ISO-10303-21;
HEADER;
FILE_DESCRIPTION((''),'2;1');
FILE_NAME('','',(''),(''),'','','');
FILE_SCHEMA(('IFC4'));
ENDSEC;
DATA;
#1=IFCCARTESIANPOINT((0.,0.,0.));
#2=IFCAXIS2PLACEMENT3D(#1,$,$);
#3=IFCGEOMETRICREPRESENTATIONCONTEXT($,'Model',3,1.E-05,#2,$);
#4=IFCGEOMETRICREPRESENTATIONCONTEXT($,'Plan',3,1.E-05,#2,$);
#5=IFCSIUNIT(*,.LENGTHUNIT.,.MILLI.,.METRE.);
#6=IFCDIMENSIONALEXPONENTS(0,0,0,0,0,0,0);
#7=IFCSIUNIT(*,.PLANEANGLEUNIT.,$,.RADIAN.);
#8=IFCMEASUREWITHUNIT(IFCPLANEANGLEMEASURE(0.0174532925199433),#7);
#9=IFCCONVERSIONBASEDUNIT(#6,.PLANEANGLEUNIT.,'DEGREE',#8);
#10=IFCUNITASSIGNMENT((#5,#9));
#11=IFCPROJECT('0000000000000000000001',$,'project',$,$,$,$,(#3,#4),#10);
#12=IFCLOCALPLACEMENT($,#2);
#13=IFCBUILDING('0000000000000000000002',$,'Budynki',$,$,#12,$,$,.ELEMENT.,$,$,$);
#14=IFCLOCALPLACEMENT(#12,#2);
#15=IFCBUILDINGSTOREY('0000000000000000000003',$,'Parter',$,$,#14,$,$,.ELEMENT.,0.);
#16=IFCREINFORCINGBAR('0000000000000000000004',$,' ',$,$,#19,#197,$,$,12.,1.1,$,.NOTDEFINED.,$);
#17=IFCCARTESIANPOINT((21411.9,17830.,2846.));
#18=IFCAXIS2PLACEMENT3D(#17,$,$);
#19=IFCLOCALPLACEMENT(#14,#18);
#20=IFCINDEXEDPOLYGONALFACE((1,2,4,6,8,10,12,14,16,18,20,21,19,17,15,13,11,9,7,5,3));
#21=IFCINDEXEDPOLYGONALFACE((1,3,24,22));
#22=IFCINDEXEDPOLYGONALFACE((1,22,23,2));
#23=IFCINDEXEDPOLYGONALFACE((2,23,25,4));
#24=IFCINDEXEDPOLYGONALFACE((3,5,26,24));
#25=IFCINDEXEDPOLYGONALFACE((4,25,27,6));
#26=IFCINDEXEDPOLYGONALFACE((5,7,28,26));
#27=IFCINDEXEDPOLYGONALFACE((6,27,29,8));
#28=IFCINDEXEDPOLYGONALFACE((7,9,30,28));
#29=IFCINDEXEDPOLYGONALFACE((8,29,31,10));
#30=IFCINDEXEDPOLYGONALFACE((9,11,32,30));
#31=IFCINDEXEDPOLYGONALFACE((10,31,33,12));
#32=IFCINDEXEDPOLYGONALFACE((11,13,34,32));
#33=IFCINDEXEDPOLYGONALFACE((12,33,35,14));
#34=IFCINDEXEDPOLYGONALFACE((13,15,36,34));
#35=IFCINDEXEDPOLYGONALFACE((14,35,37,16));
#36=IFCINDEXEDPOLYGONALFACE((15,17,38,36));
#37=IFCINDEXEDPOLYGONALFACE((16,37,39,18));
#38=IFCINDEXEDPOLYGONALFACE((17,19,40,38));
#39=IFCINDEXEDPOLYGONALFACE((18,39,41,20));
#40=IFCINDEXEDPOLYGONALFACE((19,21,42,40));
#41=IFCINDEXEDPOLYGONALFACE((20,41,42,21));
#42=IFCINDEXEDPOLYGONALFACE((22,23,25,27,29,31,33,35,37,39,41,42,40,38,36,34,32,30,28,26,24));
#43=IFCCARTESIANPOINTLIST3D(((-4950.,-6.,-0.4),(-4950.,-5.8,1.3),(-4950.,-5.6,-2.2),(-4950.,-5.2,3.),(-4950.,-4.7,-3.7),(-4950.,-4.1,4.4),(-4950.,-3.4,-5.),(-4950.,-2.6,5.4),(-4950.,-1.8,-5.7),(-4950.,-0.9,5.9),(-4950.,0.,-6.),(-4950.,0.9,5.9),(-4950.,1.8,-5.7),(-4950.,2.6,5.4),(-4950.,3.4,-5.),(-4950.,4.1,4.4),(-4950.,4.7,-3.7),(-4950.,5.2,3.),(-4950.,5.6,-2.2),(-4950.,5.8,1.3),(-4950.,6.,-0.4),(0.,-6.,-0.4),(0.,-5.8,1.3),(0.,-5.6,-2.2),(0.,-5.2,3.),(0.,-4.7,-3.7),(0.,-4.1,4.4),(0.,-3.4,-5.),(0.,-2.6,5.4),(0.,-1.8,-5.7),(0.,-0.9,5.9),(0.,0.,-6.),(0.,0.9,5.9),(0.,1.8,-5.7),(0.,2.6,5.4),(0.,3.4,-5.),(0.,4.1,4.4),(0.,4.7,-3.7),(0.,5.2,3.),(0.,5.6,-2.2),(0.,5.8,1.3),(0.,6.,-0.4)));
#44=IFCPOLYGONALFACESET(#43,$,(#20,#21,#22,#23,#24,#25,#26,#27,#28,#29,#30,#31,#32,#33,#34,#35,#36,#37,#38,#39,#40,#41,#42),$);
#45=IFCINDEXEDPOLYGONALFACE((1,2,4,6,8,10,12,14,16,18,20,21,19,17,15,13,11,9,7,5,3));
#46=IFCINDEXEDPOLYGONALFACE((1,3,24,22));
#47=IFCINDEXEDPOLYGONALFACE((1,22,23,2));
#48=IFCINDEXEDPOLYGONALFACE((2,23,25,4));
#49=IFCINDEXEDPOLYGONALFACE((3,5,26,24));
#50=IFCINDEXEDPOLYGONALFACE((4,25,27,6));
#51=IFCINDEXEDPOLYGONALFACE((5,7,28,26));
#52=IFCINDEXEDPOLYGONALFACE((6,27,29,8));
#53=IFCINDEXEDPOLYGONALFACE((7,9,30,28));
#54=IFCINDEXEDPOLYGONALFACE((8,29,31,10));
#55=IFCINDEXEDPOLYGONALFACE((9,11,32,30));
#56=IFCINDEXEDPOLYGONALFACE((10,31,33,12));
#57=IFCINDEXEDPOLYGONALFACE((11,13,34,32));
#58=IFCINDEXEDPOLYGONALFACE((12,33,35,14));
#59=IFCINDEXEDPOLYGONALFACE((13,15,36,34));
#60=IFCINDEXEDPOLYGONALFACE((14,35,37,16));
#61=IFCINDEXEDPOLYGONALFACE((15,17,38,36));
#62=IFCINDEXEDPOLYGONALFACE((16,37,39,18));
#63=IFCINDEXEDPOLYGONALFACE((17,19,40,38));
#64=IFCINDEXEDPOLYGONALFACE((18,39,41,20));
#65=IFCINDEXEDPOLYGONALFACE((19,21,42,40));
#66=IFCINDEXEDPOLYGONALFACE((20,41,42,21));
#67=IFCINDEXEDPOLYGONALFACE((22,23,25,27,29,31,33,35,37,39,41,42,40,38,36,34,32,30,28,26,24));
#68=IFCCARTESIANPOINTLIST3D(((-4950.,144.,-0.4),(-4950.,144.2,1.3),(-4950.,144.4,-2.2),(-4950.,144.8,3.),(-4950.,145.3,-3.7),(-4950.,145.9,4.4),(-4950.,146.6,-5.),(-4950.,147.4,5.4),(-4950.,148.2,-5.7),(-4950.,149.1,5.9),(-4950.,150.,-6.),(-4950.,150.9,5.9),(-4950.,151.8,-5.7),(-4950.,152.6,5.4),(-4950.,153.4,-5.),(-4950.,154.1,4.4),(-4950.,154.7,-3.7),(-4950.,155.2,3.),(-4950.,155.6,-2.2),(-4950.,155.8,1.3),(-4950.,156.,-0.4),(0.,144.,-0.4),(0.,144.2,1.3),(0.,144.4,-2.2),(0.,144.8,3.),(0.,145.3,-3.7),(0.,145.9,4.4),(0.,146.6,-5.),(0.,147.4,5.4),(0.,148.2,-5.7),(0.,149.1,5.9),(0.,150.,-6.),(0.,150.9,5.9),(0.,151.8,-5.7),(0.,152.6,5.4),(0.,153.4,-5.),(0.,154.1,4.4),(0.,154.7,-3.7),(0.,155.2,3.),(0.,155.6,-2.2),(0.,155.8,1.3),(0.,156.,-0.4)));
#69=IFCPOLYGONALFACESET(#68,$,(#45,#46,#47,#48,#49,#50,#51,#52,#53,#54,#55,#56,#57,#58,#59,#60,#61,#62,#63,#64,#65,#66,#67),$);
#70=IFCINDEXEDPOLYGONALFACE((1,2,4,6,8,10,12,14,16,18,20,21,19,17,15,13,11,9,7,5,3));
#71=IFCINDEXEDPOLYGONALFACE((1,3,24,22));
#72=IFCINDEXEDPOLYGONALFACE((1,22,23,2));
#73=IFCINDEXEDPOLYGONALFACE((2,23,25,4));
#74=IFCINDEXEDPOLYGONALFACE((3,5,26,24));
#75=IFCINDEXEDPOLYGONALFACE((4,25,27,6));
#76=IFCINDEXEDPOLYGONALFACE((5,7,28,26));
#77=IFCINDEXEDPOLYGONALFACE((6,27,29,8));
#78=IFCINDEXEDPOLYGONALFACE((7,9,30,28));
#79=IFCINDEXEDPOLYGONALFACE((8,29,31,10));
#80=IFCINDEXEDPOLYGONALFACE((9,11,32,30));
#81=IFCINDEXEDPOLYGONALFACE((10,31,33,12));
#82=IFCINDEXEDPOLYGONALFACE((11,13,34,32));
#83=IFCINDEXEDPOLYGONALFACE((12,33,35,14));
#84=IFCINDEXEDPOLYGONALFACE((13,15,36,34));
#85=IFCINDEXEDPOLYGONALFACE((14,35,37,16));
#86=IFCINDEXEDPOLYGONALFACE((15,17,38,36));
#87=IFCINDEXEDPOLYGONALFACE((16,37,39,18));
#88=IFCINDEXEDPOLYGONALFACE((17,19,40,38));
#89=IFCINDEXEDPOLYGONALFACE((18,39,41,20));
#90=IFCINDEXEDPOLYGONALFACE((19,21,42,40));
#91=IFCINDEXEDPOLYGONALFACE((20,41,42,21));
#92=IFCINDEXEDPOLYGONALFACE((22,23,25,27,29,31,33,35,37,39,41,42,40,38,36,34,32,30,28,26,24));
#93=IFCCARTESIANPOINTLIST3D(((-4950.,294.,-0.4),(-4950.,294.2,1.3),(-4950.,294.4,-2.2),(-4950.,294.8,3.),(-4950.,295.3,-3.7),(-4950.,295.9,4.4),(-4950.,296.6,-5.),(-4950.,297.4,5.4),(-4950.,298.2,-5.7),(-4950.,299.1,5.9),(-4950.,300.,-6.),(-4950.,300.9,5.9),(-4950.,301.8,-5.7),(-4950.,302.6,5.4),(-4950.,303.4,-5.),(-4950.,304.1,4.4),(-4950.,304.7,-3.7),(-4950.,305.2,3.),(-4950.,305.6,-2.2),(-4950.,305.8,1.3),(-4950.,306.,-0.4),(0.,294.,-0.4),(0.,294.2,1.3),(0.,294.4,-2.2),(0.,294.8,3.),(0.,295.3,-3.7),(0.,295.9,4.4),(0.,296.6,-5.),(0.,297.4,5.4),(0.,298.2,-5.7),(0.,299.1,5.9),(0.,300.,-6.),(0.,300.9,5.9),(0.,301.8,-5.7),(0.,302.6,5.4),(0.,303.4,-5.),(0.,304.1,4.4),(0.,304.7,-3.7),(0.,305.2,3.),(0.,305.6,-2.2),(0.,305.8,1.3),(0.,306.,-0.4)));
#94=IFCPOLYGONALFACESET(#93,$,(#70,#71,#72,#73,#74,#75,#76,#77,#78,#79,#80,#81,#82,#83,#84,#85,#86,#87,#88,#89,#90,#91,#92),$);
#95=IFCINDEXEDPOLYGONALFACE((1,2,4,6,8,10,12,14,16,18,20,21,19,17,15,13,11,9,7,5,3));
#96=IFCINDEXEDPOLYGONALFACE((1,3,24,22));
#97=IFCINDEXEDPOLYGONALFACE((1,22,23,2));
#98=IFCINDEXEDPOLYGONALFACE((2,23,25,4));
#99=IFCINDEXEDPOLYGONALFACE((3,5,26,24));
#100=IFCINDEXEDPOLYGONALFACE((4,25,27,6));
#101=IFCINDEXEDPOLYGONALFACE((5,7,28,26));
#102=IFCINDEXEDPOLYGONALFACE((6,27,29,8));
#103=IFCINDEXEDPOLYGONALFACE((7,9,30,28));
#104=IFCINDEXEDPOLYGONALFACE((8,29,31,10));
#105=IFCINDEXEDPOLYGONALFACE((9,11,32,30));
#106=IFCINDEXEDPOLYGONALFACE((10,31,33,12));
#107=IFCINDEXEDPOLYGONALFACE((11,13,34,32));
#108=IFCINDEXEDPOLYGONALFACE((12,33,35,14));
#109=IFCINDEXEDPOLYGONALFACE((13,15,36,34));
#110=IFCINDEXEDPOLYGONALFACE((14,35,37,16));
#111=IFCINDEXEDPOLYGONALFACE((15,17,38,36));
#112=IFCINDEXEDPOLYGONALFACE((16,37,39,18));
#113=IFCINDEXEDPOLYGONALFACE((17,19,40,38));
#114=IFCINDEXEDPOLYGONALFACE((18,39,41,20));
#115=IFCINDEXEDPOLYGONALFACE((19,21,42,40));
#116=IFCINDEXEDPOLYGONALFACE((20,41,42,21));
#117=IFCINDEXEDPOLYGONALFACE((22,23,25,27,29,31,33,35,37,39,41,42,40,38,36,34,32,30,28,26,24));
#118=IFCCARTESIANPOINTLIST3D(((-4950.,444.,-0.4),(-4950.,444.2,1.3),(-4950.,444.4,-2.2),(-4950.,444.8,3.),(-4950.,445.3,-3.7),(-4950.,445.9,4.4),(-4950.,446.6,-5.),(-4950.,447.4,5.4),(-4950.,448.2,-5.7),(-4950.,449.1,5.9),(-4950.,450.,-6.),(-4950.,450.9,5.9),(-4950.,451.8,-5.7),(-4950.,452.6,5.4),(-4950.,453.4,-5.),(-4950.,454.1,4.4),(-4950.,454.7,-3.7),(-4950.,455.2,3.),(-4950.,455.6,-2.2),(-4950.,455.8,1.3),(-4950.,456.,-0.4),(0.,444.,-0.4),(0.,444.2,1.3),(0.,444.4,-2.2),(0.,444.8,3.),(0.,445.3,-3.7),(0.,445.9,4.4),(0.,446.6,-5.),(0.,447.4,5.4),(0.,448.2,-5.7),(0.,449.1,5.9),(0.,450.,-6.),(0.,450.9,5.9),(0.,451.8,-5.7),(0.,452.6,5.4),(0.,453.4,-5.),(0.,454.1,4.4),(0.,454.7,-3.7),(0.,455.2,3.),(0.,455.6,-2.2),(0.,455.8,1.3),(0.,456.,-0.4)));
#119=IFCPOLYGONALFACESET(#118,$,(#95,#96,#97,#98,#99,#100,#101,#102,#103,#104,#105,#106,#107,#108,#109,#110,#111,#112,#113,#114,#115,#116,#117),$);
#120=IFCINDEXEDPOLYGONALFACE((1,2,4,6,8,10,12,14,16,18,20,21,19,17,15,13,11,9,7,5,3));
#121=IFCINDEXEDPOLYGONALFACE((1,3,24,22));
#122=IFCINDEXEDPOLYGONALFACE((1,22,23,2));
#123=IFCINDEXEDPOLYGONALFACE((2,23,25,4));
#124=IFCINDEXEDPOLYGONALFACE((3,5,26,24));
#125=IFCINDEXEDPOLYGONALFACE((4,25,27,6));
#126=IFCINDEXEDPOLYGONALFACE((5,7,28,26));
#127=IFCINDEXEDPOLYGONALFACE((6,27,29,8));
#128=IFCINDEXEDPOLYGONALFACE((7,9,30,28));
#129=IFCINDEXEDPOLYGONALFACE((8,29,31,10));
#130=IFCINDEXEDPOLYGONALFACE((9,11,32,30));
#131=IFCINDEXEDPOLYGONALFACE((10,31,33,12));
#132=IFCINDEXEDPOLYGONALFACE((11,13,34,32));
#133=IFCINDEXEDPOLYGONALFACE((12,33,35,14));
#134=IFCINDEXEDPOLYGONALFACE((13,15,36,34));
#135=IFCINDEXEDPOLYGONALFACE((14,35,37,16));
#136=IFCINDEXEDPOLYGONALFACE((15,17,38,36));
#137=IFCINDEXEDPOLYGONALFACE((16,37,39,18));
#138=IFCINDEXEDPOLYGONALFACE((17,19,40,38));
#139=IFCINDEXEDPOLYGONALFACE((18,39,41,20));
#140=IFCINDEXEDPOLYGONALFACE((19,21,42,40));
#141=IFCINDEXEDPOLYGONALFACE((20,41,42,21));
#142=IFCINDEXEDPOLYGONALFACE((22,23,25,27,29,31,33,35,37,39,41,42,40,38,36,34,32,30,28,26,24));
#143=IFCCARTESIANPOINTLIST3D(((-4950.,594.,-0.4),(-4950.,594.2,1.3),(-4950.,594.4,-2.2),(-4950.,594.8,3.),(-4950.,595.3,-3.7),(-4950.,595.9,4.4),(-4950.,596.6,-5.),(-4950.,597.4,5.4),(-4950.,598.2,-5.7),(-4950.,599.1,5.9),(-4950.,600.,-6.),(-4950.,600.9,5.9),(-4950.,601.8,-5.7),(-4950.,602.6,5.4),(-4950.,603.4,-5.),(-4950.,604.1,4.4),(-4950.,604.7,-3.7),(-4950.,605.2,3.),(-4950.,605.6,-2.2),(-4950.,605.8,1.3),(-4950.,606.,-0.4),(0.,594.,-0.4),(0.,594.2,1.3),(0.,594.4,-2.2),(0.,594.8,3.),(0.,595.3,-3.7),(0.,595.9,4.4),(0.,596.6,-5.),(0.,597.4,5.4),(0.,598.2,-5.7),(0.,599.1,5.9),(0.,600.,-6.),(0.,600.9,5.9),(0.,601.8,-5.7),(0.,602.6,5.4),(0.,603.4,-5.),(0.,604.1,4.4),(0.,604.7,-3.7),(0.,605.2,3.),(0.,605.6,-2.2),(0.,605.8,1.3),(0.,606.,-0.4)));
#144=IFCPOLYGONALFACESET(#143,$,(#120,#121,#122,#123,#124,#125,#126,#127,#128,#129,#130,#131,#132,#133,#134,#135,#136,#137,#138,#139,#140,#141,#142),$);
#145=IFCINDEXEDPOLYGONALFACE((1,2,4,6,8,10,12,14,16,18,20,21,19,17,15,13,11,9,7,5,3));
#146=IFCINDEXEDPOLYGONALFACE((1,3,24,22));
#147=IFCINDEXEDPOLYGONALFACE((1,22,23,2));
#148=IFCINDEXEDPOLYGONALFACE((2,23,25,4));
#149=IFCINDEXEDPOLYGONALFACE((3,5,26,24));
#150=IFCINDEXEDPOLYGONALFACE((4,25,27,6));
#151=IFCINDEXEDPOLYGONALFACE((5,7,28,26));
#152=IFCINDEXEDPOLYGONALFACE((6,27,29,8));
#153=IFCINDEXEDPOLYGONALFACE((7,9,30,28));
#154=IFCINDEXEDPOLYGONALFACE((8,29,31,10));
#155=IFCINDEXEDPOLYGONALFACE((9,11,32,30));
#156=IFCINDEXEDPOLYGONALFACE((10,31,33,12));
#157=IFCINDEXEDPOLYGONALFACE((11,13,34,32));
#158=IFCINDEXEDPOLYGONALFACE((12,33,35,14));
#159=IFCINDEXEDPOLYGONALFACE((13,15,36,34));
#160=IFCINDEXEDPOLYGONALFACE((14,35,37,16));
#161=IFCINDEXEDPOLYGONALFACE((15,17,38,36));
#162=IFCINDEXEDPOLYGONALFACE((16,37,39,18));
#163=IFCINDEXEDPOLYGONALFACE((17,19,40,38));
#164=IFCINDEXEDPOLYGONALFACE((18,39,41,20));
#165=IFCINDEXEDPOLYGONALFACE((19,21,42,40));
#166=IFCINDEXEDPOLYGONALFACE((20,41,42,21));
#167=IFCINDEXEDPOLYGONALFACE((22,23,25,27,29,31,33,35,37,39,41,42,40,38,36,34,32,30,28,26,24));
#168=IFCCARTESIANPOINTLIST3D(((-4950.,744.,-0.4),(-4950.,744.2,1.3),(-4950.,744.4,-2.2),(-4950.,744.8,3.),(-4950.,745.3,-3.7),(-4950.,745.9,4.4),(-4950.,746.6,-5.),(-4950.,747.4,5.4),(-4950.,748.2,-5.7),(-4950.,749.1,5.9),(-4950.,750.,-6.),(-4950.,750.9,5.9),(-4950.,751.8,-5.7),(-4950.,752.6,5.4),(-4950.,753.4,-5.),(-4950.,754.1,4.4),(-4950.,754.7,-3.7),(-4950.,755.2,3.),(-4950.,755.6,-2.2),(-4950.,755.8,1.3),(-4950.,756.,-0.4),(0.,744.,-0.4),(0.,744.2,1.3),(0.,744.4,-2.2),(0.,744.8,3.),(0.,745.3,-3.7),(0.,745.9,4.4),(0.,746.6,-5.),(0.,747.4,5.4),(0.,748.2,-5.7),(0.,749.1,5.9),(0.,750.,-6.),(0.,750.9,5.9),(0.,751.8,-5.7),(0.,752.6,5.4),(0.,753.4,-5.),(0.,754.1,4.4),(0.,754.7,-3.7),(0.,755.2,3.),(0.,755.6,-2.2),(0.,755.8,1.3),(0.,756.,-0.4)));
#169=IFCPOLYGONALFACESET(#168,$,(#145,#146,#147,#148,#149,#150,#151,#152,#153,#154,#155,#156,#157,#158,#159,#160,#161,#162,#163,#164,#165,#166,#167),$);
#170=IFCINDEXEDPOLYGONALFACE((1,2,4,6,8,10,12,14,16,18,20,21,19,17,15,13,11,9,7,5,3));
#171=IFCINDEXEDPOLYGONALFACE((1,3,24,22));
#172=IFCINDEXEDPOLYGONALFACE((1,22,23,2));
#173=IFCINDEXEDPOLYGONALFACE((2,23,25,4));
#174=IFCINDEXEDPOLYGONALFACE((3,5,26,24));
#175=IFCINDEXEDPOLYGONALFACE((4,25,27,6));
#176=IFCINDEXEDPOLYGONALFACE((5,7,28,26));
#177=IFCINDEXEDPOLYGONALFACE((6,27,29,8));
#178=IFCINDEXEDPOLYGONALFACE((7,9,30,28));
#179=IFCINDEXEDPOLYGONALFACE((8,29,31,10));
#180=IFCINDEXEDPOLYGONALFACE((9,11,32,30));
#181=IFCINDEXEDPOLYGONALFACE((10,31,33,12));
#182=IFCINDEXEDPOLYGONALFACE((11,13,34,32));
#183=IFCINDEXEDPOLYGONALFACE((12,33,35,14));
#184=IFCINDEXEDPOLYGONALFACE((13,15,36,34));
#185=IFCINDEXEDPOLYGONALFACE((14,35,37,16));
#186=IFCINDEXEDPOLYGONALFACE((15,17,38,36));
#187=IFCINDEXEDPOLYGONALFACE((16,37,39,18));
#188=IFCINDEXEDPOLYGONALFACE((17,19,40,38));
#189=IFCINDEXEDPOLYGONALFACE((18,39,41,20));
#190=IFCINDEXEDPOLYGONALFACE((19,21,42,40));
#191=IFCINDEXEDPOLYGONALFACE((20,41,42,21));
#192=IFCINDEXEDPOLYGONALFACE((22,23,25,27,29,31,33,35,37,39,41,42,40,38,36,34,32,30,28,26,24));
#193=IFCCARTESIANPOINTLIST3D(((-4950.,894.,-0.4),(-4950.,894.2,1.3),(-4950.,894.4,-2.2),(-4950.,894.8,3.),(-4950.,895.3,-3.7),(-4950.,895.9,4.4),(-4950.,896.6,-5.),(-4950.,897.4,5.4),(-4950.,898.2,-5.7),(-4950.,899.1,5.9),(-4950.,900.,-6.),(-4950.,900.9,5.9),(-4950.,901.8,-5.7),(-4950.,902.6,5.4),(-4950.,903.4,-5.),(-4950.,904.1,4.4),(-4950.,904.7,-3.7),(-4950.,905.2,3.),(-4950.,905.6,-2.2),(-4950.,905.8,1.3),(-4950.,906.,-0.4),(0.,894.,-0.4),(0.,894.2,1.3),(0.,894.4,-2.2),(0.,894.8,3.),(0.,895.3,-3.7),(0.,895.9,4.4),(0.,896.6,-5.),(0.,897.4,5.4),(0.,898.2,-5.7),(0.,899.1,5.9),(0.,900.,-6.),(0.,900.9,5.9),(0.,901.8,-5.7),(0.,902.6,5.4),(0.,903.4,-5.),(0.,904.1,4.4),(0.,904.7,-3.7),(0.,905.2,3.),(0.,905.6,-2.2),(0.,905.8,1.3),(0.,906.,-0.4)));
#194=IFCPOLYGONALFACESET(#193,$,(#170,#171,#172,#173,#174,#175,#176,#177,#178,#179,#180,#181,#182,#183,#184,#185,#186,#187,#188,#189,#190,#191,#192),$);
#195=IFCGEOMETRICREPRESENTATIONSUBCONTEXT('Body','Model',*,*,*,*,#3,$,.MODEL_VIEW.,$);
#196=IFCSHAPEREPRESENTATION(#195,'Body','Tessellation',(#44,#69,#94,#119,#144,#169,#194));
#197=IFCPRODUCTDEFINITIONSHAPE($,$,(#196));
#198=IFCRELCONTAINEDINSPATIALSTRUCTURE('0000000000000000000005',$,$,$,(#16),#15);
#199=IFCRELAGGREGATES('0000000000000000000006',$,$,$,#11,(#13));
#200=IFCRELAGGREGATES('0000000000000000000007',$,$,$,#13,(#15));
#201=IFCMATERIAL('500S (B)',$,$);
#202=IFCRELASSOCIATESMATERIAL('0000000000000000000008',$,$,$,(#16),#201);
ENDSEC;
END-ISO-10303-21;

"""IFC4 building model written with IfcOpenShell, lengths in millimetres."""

from ifc_helpers import new_model, entity, si_unit, converted_unit, frame, origin, place, context, subcontext, project, spatial, material, element, save


model = new_model("IFC4")

# Units and contexts
model_context = context("Model", 3, precision=1e-05, world=origin())
plan_context = context("Plan", 3, precision=1e-05, world=origin())
body_context = subcontext(model_context, "Body", "Model", "MODEL_VIEW")
ifc_project = project(units=[si_unit("LENGTHUNIT", "METRE", prefix="MILLI"), converted_unit("PLANEANGLEUNIT", "DEGREE", entity("IfcPlaneAngleMeasure", 0.0174532925199433), si_unit("PLANEANGLEUNIT", "RADIAN"), dimensions=[0, 0, 0, 0, 0, 0, 0])], contexts=[model_context, plan_context])

# Building, storey
building_placement = place(None, origin())
building = spatial("IfcBuilding", under=ifc_project, at=building_placement, Name="Budynki", CompositionType="ELEMENT")
storey_placement = place(building_placement, origin())
storey = spatial("IfcBuildingStorey", under=building, at=storey_placement, Name="Parter", CompositionType="ELEMENT", Elevation=0.0)

# Reinforcing bar
ifc_material_1 = material(Name="500S (B)")
reinforcing_bar_1_placement = place(storey_placement, frame((21411.9, 17830.0, 2846.0)))
element("IfcReinforcingBar", 1, at=reinforcing_bar_1_placement, inside=storey, material=ifc_material_1, Name=" ", CrossSectionArea=1.1, NominalDiameter=12.0, PredefinedType="NOTDEFINED", context=body_context, shape_type="AdvancedSweptSolid", body=[
    entity("IfcSweptDiskSolid", entity("IfcPolyline", [entity("IfcCartesianPoint", [0.0, 0.0, 0.0]), entity("IfcCartesianPoint", [-4950.0, 0.0, 0.0])]), 6.0, None, 0.0, 1.0),
    entity("IfcSweptDiskSolid", entity("IfcPolyline", [entity("IfcCartesianPoint", [0.0, 150.0, 0.0]), entity("IfcCartesianPoint", [-4950.0, 150.0, 0.0])]), 6.0, None, 0.0, 1.0),
    entity("IfcSweptDiskSolid", entity("IfcPolyline", [entity("IfcCartesianPoint", [0.0, 300.0, 0.0]), entity("IfcCartesianPoint", [-4950.0, 300.0, 0.0])]), 6.0, None, 0.0, 1.0),
    entity("IfcSweptDiskSolid", entity("IfcPolyline", [entity("IfcCartesianPoint", [0.0, 450.0, 0.0]), entity("IfcCartesianPoint", [-4950.0, 450.0, 0.0])]), 6.0, None, 0.0, 1.0),
    entity("IfcSweptDiskSolid", entity("IfcPolyline", [entity("IfcCartesianPoint", [0.0, 600.0, 0.0]), entity("IfcCartesianPoint", [-4950.0, 600.0, 0.0])]), 6.0, None, 0.0, 1.0),
    entity("IfcSweptDiskSolid", entity("IfcPolyline", [entity("IfcCartesianPoint", [0.0, 750.0, 0.0]), entity("IfcCartesianPoint", [-4950.0, 750.0, 0.0])]), 6.0, None, 0.0, 1.0),
    entity("IfcSweptDiskSolid", entity("IfcPolyline", [entity("IfcCartesianPoint", [0.0, 900.0, 0.0]), entity("IfcCartesianPoint", [-4950.0, 900.0, 0.0])]), 6.0, None, 0.0, 1.0),
])

save(model, "model.ifc")
